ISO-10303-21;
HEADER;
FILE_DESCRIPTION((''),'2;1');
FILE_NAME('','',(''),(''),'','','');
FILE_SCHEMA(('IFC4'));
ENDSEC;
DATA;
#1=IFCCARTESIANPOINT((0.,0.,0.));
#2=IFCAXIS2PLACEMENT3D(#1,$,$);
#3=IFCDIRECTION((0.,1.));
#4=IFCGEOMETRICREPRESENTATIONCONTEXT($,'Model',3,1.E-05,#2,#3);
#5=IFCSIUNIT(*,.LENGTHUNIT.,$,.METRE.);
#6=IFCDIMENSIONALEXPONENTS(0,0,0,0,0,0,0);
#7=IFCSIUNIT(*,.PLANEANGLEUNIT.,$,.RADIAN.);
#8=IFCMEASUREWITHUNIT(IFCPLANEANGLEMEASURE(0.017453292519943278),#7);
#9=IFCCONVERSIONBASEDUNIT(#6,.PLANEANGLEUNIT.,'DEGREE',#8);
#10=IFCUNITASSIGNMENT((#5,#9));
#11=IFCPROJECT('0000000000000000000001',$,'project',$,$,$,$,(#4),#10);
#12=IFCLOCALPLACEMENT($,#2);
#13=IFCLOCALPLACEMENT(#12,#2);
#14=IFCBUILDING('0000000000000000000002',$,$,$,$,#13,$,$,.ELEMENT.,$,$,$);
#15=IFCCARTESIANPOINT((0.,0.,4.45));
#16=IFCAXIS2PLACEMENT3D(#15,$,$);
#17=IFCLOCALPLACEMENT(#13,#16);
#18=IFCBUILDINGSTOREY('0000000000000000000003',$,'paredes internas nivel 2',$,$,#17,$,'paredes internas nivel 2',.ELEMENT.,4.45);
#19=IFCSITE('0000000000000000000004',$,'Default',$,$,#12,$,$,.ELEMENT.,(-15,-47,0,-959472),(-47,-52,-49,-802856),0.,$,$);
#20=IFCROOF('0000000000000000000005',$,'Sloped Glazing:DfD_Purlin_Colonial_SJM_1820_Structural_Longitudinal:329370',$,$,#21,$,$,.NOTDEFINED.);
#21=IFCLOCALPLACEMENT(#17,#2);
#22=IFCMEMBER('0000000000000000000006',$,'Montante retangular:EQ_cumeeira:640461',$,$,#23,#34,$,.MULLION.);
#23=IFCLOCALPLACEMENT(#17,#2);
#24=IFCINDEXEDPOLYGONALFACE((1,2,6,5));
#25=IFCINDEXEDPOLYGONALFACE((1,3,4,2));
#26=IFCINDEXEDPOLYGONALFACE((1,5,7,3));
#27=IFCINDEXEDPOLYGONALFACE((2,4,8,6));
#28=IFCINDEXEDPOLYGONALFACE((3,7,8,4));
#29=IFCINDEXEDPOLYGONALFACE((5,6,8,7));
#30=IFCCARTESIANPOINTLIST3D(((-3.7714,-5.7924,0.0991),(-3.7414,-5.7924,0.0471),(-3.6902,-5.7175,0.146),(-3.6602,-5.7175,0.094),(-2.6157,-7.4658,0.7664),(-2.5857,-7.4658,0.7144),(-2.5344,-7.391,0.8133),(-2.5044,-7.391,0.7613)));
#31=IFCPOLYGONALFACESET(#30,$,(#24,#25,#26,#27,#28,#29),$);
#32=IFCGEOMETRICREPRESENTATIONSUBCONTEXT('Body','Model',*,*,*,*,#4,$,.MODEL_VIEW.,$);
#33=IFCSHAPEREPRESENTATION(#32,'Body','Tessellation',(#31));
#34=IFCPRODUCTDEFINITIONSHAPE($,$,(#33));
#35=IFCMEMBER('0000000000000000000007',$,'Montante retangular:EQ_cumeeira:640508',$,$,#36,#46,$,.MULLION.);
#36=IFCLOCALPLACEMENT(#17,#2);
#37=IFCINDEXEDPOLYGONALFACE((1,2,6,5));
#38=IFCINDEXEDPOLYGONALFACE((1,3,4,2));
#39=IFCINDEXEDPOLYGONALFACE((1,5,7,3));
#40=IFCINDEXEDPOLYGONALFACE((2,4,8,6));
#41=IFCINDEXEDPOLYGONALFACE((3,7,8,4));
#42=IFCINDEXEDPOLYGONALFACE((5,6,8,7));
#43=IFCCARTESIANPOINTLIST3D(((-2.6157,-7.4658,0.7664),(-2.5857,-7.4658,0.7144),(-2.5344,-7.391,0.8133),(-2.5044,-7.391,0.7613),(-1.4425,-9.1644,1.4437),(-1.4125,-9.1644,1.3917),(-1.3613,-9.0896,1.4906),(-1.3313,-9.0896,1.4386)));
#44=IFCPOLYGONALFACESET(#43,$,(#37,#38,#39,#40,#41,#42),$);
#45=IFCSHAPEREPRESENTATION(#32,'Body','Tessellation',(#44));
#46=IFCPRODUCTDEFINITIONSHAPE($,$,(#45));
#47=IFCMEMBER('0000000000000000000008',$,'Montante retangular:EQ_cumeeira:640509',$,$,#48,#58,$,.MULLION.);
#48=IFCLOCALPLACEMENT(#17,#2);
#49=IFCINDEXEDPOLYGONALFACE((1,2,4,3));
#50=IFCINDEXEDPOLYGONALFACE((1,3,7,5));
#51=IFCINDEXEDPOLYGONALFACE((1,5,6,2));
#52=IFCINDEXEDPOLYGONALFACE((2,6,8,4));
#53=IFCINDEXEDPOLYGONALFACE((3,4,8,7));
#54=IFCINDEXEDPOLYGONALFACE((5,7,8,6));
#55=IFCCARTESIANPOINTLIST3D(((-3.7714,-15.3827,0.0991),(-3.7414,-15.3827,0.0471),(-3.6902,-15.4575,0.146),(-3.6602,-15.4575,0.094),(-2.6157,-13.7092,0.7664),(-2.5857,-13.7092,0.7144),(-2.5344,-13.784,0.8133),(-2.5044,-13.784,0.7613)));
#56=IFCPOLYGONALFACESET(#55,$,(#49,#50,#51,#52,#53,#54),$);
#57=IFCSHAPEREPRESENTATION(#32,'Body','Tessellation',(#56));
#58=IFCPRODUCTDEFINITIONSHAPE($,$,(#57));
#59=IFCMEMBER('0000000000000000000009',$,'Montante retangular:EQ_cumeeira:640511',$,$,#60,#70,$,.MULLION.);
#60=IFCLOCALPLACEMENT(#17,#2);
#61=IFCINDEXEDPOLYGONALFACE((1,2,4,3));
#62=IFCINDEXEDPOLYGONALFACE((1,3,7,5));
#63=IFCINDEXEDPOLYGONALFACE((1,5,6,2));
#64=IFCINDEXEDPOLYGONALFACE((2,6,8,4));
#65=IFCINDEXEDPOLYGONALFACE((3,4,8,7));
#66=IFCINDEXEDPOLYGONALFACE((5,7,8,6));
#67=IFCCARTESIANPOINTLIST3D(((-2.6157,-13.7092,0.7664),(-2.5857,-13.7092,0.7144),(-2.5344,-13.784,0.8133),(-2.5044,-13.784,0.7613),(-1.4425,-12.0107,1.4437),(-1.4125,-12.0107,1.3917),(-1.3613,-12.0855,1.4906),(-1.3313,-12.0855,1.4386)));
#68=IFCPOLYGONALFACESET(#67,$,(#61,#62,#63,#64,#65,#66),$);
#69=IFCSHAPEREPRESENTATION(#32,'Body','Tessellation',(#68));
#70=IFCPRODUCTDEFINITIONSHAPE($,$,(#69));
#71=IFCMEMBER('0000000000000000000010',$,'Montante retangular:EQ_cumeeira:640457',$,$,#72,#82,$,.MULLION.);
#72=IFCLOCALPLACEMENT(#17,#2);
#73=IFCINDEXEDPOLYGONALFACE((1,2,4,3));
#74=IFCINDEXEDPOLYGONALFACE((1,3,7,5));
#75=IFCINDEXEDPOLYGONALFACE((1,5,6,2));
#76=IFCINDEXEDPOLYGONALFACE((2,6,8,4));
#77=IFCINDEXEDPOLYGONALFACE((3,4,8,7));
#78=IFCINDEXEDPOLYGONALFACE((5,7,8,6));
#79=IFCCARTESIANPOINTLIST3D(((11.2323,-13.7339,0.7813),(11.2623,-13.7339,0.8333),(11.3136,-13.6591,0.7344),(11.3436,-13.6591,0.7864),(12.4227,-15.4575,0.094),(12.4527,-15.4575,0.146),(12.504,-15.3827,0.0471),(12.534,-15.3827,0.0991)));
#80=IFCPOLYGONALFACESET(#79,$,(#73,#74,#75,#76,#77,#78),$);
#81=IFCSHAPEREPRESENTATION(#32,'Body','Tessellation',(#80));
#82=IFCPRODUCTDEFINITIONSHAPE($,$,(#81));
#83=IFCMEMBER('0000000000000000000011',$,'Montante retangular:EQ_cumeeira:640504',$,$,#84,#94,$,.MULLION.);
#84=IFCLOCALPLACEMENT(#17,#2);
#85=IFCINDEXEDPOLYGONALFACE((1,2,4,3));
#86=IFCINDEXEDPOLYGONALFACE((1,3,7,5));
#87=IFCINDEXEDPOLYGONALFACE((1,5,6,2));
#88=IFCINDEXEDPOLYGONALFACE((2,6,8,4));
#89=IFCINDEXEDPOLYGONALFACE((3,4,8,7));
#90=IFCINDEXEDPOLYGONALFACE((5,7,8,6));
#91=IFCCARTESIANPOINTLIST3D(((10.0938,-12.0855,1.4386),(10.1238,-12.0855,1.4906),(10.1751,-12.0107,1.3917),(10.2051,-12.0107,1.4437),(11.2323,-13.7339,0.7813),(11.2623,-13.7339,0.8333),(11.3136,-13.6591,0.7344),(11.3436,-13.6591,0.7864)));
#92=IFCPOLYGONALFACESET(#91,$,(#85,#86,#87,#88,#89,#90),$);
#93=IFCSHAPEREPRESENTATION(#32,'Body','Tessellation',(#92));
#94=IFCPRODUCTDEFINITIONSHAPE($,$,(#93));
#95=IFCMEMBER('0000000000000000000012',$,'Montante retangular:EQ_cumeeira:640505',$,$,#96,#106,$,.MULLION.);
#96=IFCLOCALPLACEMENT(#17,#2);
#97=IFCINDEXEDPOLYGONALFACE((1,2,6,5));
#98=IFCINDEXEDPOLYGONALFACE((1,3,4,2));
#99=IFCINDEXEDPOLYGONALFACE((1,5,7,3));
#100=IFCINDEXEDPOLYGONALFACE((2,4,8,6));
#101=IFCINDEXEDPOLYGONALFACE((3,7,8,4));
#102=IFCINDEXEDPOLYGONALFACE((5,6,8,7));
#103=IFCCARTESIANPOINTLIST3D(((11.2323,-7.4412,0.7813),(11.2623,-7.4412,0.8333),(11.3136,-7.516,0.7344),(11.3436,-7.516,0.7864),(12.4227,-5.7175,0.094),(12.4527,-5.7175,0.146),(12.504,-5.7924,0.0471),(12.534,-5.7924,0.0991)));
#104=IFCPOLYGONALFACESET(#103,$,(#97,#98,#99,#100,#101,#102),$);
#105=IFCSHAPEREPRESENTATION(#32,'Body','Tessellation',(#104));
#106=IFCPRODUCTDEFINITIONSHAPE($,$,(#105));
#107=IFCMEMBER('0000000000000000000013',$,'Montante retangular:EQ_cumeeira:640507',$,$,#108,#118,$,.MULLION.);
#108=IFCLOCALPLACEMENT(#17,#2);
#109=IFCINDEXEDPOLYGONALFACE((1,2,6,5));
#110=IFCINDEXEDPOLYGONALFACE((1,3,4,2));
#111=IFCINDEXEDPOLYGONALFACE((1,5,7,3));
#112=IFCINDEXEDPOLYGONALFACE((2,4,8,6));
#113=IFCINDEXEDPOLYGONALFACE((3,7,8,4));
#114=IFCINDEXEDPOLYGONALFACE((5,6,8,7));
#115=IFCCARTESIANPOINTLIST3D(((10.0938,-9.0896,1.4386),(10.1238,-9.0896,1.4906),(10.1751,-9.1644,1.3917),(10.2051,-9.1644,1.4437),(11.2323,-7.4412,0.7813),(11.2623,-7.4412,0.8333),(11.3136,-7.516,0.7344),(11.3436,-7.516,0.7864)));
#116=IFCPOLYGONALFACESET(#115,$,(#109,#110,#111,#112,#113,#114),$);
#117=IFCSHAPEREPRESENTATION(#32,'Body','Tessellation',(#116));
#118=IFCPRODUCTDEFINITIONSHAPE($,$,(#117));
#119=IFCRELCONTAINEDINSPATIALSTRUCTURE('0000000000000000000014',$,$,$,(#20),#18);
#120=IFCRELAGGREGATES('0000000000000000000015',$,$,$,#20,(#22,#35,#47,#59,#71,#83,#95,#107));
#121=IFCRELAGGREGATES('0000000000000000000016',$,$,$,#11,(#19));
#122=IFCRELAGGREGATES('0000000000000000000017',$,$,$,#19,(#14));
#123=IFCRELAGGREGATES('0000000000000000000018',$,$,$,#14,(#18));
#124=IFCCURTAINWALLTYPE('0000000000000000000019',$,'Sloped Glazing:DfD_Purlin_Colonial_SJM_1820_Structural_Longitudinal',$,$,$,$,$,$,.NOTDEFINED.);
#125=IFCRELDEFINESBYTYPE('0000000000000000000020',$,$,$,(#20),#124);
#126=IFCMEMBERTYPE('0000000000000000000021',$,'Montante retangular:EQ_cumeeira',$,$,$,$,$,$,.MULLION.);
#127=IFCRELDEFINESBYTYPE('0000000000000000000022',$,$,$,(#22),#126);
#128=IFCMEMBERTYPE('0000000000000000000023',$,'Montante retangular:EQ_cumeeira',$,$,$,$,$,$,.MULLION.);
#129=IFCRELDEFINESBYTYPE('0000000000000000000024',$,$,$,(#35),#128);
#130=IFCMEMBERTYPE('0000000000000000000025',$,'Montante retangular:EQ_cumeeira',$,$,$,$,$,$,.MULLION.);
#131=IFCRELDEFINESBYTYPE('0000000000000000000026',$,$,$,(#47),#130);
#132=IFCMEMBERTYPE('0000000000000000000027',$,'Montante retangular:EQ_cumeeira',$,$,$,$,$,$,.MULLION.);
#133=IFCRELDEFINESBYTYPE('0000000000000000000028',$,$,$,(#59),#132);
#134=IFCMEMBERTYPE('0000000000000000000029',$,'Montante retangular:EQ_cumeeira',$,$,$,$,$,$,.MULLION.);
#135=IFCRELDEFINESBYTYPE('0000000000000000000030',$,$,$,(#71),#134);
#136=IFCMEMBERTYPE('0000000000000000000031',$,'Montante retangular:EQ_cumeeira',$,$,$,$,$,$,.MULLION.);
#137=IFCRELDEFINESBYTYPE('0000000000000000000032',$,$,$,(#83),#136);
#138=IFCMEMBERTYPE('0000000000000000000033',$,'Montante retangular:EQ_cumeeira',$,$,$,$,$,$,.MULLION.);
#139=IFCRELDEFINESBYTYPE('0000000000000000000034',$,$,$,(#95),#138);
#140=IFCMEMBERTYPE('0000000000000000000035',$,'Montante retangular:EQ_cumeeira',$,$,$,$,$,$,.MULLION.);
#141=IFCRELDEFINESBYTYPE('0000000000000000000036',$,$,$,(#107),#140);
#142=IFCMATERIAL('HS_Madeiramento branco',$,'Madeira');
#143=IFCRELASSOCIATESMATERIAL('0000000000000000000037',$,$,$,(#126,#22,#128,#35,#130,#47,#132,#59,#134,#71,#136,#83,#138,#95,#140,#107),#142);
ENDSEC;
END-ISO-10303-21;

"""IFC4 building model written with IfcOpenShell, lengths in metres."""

from ifc_helpers import new_model, entity, si_unit, converted_unit, direction, frame, origin, place, context, subcontext, project, spatial, indexed_curve, outline, extrude, source, transform, mapped, material, type_object, type_shapes, element, aggregate, save


model = new_model("IFC4")

# Units and contexts
model_context = context("Model", 3, precision=1e-05, world=origin(), true_north=direction((0.0, 1.0)))
body_context = subcontext(model_context, "Body", "Model", "MODEL_VIEW")
ifc_project = project(units=[si_unit("LENGTHUNIT", "METRE"), converted_unit("PLANEANGLEUNIT", "DEGREE", entity("IfcPlaneAngleMeasure", 0.017453292519943278), si_unit("PLANEANGLEUNIT", "RADIAN"), dimensions=[0, 0, 0, 0, 0, 0, 0])], contexts=[model_context])

# Site, building, storey
site_placement = place(None, origin())
site = spatial("IfcSite", under=ifc_project, at=site_placement, Name="Default", CompositionType="ELEMENT", RefLatitude=(-15, -47, 0, -959472), RefLongitude=(-47, -52, -49, -802856), RefElevation=0.0)
building_placement = place(site_placement, origin())
building = spatial("IfcBuilding", under=site, at=building_placement, CompositionType="ELEMENT")
storey_placement = place(building_placement, frame((0.0, 0.0, 4.45)))
storey = spatial("IfcBuildingStorey", under=building, at=storey_placement, Name="paredes internas nivel 2", LongName="paredes internas nivel 2", CompositionType="ELEMENT", Elevation=4.45)

# Roof, members
curtain_wall_type = type_object("IfcCurtainWallType", Name="Sloped Glazing:DfD_Purlin_Colonial_SJM_1820_Structural_Longitudinal", PredefinedType="NOTDEFINED")
roof_placement = place(storey_placement, frame((0.0, 0.0, -4.45)))
roof = element("IfcRoof", 1, at=roof_placement, inside=storey, type_object=curtain_wall_type, Name="Sloped Glazing:DfD_Purlin_Colonial_SJM_1820_Structural_Longitudinal:329370", PredefinedType="NOTDEFINED")
ifc_material = material(Name="HS_Madeiramento branco", Category="Madeira")
member_type_1 = type_object("IfcMemberType", Name="Montante retangular:EQ_cumeeira", PredefinedType="MULLION", material=ifc_material)
shared_shape_1 = source(origin(), body_context, "Body", "SweptSolid", [
    extrude(outline(indexed_curve([(-0.06, -0.03), (0.06, -0.03), (0.06, 0.03), (-0.06, 0.03), (-0.06, -0.03)], self_intersect=False)), frame((-0.06, 0.0, -2.1405), z_axis=(0.0, 0.0, 1.0), x_axis=(-1.0, 0.0, 0.0)), (0.0, 0.0, 1.0), 2.1405),
])
type_shapes(member_type_1, [shared_shape_1])
member_1_placement = place(roof_placement, frame((-3.6752, -5.7175, 4.57), z_axis=(-0.539965, 0.781825, -0.311749), x_axis=(0.67708, 0.623498, 0.390913)))
member_1 = element("IfcMember", 2, at=member_1_placement, type_object=member_type_1, material=ifc_material, Name="Montante retangular:EQ_cumeeira:640461", PredefinedType="MULLION", context=body_context, shape_type="MappedRepresentation", body=[
    mapped(shared_shape_1, transform((0.0, 0.0, 0.0), scale=1.0)),
])
member_type_2 = type_object("IfcMemberType", Name="Montante retangular:EQ_cumeeira", PredefinedType="MULLION", material=ifc_material)
shared_shape_2 = source(origin(), body_context, "Body", "SweptSolid", [
    extrude(outline(indexed_curve([(-0.06, -0.03), (0.06, -0.03), (0.06, 0.03), (-0.06, 0.03), (-0.06, -0.03)], self_intersect=False)), frame((-0.06, 0.0, -2.1726), z_axis=(0.0, 0.0, 1.0), x_axis=(-1.0, 0.0, 0.0)), (0.0, 0.0, 1.0), 2.1726),
])
type_shapes(member_type_2, [shared_shape_2])
member_2_placement = place(roof_placement, frame((-2.5194, -7.391, 5.2373), z_axis=(-0.539965, 0.781825, -0.311749), x_axis=(0.67708, 0.623498, 0.390913)))
member_2 = element("IfcMember", 3, at=member_2_placement, type_object=member_type_2, material=ifc_material, Name="Montante retangular:EQ_cumeeira:640508", PredefinedType="MULLION", context=body_context, shape_type="MappedRepresentation", body=[
    mapped(shared_shape_2, transform((0.0, 0.0, 0.0), scale=1.0)),
])
member_type_3 = type_object("IfcMemberType", Name="Montante retangular:EQ_cumeeira", PredefinedType="MULLION", material=ifc_material)
shared_shape_3 = source(origin(), body_context, "Body", "SweptSolid", [
    extrude(outline(indexed_curve([(-0.06, -0.03), (0.06, -0.03), (0.06, 0.03), (-0.06, 0.03), (-0.06, -0.03)], self_intersect=False)), frame((-0.06, 0.0, -2.1405), z_axis=(0.0, 0.0, 1.0), x_axis=(-1.0, 0.0, 0.0)), (0.0, 0.0, 1.0), 2.1405),
])
type_shapes(member_type_3, [shared_shape_3])
member_3_placement = place(roof_placement, frame((-2.5194, -13.784, 5.2373), z_axis=(0.539965, 0.781825, 0.311749), x_axis=(0.67708, -0.623498, 0.390913)))
member_3 = element("IfcMember", 4, at=member_3_placement, type_object=member_type_3, material=ifc_material, Name="Montante retangular:EQ_cumeeira:640509", PredefinedType="MULLION", context=body_context, shape_type="MappedRepresentation", body=[
    mapped(shared_shape_3, transform((0.0, 0.0, 0.0), scale=1.0)),
])
member_type_4 = type_object("IfcMemberType", Name="Montante retangular:EQ_cumeeira", PredefinedType="MULLION", material=ifc_material)
shared_shape_4 = source(origin(), body_context, "Body", "SweptSolid", [
    extrude(outline(indexed_curve([(-0.06, -0.03), (0.06, -0.03), (0.06, 0.03), (-0.06, 0.03), (-0.06, -0.03)], self_intersect=False)), frame((-0.06, 0.0, -2.1726), z_axis=(0.0, 0.0, 1.0), x_axis=(-1.0, 0.0, 0.0)), (0.0, 0.0, 1.0), 2.1726),
])
type_shapes(member_type_4, [shared_shape_4])
member_4_placement = place(roof_placement, frame((-1.3463, -12.0855, 5.9146), z_axis=(0.539965, 0.781825, 0.311749), x_axis=(0.67708, -0.623498, 0.390913)))
member_4 = element("IfcMember", 5, at=member_4_placement, type_object=member_type_4, material=ifc_material, Name="Montante retangular:EQ_cumeeira:640511", PredefinedType="MULLION", context=body_context, shape_type="MappedRepresentation", body=[
    mapped(shared_shape_4, transform((0.0, 0.0, 0.0), scale=1.0)),
])
member_type_5 = type_object("IfcMemberType", Name="Montante retangular:EQ_cumeeira", PredefinedType="MULLION", material=ifc_material)
shared_shape_5 = source(origin(), body_context, "Body", "SweptSolid", [
    extrude(outline(indexed_curve([(-0.06, -0.03), (0.06, -0.03), (0.06, 0.03), (-0.06, 0.03), (-0.06, -0.03)], self_intersect=False)), frame((-0.06, 0.0, -2.2046), z_axis=(0.0, 0.0, 1.0), x_axis=(-1.0, 0.0, 0.0)), (0.0, 0.0, 1.0), 2.2046),
])
type_shapes(member_type_5, [shared_shape_5])
member_5_placement = place(roof_placement, frame((12.4377, -15.4575, 4.57), z_axis=(0.539965, -0.781825, -0.311749), x_axis=(-0.67708, -0.623498, 0.390913)))
member_5 = element("IfcMember", 6, at=member_5_placement, type_object=member_type_5, material=ifc_material, Name="Montante retangular:EQ_cumeeira:640457", PredefinedType="MULLION", context=body_context, shape_type="MappedRepresentation", body=[
    mapped(shared_shape_5, transform((0.0, 0.0, 0.0), scale=1.0)),
])
member_type_6 = type_object("IfcMemberType", Name="Montante retangular:EQ_cumeeira", PredefinedType="MULLION", material=ifc_material)
shared_shape_6 = source(origin(), body_context, "Body", "SweptSolid", [
    extrude(outline(indexed_curve([(-0.06, -0.03), (0.06, -0.03), (0.06, 0.03), (-0.06, 0.03), (-0.06, -0.03)], self_intersect=False)), frame((-0.06, 0.0, -2.1084), z_axis=(0.0, 0.0, 1.0), x_axis=(-1.0, 0.0, 0.0)), (0.0, 0.0, 1.0), 2.1084),
])
type_shapes(member_type_6, [shared_shape_6])
member_6_placement = place(roof_placement, frame((11.2473, -13.7339, 5.2573), z_axis=(0.539965, -0.781825, -0.311749), x_axis=(-0.67708, -0.623498, 0.390913)))
member_6 = element("IfcMember", 7, at=member_6_placement, type_object=member_type_6, material=ifc_material, Name="Montante retangular:EQ_cumeeira:640504", PredefinedType="MULLION", context=body_context, shape_type="MappedRepresentation", body=[
    mapped(shared_shape_6, transform((0.0, 0.0, 0.0), scale=1.0)),
])
member_type_7 = type_object("IfcMemberType", Name="Montante retangular:EQ_cumeeira", PredefinedType="MULLION", material=ifc_material)
shared_shape_7 = source(origin(), body_context, "Body", "SweptSolid", [
    extrude(outline(indexed_curve([(-0.06, -0.03), (0.06, -0.03), (0.06, 0.03), (-0.06, 0.03), (-0.06, -0.03)], self_intersect=False)), frame((-0.06, 0.0, -2.2046), z_axis=(0.0, 0.0, 1.0), x_axis=(-1.0, 0.0, 0.0)), (0.0, 0.0, 1.0), 2.2046),
])
type_shapes(member_type_7, [shared_shape_7])
member_7_placement = place(roof_placement, frame((11.2473, -7.4412, 5.2573), z_axis=(-0.539965, -0.781825, 0.311749), x_axis=(-0.67708, 0.623498, 0.390913)))
member_7 = element("IfcMember", 8, at=member_7_placement, type_object=member_type_7, material=ifc_material, Name="Montante retangular:EQ_cumeeira:640505", PredefinedType="MULLION", context=body_context, shape_type="MappedRepresentation", body=[
    mapped(shared_shape_7, transform((0.0, 0.0, 0.0), scale=1.0)),
])
member_type_8 = type_object("IfcMemberType", Name="Montante retangular:EQ_cumeeira", PredefinedType="MULLION", material=ifc_material)
shared_shape_8 = source(origin(), body_context, "Body", "SweptSolid", [
    extrude(outline(indexed_curve([(-0.06, -0.03), (0.06, -0.03), (0.06, 0.03), (-0.06, 0.03), (-0.06, -0.03)], self_intersect=False)), frame((-0.06, 0.0, -2.1084), z_axis=(0.0, 0.0, 1.0), x_axis=(-1.0, 0.0, 0.0)), (0.0, 0.0, 1.0), 2.1084),
])
type_shapes(member_type_8, [shared_shape_8])
member_8_placement = place(roof_placement, frame((10.1088, -9.0896, 5.9146), z_axis=(-0.539965, -0.781825, 0.311749), x_axis=(-0.67708, 0.623498, 0.390913)))
member_8 = element("IfcMember", 9, at=member_8_placement, type_object=member_type_8, material=ifc_material, Name="Montante retangular:EQ_cumeeira:640507", PredefinedType="MULLION", context=body_context, shape_type="MappedRepresentation", body=[
    mapped(shared_shape_8, transform((0.0, 0.0, 0.0), scale=1.0)),
])
aggregate(roof, [member_1, member_2, member_3, member_4, member_5, member_6, member_7, member_8])

save(model, "model.ifc")
